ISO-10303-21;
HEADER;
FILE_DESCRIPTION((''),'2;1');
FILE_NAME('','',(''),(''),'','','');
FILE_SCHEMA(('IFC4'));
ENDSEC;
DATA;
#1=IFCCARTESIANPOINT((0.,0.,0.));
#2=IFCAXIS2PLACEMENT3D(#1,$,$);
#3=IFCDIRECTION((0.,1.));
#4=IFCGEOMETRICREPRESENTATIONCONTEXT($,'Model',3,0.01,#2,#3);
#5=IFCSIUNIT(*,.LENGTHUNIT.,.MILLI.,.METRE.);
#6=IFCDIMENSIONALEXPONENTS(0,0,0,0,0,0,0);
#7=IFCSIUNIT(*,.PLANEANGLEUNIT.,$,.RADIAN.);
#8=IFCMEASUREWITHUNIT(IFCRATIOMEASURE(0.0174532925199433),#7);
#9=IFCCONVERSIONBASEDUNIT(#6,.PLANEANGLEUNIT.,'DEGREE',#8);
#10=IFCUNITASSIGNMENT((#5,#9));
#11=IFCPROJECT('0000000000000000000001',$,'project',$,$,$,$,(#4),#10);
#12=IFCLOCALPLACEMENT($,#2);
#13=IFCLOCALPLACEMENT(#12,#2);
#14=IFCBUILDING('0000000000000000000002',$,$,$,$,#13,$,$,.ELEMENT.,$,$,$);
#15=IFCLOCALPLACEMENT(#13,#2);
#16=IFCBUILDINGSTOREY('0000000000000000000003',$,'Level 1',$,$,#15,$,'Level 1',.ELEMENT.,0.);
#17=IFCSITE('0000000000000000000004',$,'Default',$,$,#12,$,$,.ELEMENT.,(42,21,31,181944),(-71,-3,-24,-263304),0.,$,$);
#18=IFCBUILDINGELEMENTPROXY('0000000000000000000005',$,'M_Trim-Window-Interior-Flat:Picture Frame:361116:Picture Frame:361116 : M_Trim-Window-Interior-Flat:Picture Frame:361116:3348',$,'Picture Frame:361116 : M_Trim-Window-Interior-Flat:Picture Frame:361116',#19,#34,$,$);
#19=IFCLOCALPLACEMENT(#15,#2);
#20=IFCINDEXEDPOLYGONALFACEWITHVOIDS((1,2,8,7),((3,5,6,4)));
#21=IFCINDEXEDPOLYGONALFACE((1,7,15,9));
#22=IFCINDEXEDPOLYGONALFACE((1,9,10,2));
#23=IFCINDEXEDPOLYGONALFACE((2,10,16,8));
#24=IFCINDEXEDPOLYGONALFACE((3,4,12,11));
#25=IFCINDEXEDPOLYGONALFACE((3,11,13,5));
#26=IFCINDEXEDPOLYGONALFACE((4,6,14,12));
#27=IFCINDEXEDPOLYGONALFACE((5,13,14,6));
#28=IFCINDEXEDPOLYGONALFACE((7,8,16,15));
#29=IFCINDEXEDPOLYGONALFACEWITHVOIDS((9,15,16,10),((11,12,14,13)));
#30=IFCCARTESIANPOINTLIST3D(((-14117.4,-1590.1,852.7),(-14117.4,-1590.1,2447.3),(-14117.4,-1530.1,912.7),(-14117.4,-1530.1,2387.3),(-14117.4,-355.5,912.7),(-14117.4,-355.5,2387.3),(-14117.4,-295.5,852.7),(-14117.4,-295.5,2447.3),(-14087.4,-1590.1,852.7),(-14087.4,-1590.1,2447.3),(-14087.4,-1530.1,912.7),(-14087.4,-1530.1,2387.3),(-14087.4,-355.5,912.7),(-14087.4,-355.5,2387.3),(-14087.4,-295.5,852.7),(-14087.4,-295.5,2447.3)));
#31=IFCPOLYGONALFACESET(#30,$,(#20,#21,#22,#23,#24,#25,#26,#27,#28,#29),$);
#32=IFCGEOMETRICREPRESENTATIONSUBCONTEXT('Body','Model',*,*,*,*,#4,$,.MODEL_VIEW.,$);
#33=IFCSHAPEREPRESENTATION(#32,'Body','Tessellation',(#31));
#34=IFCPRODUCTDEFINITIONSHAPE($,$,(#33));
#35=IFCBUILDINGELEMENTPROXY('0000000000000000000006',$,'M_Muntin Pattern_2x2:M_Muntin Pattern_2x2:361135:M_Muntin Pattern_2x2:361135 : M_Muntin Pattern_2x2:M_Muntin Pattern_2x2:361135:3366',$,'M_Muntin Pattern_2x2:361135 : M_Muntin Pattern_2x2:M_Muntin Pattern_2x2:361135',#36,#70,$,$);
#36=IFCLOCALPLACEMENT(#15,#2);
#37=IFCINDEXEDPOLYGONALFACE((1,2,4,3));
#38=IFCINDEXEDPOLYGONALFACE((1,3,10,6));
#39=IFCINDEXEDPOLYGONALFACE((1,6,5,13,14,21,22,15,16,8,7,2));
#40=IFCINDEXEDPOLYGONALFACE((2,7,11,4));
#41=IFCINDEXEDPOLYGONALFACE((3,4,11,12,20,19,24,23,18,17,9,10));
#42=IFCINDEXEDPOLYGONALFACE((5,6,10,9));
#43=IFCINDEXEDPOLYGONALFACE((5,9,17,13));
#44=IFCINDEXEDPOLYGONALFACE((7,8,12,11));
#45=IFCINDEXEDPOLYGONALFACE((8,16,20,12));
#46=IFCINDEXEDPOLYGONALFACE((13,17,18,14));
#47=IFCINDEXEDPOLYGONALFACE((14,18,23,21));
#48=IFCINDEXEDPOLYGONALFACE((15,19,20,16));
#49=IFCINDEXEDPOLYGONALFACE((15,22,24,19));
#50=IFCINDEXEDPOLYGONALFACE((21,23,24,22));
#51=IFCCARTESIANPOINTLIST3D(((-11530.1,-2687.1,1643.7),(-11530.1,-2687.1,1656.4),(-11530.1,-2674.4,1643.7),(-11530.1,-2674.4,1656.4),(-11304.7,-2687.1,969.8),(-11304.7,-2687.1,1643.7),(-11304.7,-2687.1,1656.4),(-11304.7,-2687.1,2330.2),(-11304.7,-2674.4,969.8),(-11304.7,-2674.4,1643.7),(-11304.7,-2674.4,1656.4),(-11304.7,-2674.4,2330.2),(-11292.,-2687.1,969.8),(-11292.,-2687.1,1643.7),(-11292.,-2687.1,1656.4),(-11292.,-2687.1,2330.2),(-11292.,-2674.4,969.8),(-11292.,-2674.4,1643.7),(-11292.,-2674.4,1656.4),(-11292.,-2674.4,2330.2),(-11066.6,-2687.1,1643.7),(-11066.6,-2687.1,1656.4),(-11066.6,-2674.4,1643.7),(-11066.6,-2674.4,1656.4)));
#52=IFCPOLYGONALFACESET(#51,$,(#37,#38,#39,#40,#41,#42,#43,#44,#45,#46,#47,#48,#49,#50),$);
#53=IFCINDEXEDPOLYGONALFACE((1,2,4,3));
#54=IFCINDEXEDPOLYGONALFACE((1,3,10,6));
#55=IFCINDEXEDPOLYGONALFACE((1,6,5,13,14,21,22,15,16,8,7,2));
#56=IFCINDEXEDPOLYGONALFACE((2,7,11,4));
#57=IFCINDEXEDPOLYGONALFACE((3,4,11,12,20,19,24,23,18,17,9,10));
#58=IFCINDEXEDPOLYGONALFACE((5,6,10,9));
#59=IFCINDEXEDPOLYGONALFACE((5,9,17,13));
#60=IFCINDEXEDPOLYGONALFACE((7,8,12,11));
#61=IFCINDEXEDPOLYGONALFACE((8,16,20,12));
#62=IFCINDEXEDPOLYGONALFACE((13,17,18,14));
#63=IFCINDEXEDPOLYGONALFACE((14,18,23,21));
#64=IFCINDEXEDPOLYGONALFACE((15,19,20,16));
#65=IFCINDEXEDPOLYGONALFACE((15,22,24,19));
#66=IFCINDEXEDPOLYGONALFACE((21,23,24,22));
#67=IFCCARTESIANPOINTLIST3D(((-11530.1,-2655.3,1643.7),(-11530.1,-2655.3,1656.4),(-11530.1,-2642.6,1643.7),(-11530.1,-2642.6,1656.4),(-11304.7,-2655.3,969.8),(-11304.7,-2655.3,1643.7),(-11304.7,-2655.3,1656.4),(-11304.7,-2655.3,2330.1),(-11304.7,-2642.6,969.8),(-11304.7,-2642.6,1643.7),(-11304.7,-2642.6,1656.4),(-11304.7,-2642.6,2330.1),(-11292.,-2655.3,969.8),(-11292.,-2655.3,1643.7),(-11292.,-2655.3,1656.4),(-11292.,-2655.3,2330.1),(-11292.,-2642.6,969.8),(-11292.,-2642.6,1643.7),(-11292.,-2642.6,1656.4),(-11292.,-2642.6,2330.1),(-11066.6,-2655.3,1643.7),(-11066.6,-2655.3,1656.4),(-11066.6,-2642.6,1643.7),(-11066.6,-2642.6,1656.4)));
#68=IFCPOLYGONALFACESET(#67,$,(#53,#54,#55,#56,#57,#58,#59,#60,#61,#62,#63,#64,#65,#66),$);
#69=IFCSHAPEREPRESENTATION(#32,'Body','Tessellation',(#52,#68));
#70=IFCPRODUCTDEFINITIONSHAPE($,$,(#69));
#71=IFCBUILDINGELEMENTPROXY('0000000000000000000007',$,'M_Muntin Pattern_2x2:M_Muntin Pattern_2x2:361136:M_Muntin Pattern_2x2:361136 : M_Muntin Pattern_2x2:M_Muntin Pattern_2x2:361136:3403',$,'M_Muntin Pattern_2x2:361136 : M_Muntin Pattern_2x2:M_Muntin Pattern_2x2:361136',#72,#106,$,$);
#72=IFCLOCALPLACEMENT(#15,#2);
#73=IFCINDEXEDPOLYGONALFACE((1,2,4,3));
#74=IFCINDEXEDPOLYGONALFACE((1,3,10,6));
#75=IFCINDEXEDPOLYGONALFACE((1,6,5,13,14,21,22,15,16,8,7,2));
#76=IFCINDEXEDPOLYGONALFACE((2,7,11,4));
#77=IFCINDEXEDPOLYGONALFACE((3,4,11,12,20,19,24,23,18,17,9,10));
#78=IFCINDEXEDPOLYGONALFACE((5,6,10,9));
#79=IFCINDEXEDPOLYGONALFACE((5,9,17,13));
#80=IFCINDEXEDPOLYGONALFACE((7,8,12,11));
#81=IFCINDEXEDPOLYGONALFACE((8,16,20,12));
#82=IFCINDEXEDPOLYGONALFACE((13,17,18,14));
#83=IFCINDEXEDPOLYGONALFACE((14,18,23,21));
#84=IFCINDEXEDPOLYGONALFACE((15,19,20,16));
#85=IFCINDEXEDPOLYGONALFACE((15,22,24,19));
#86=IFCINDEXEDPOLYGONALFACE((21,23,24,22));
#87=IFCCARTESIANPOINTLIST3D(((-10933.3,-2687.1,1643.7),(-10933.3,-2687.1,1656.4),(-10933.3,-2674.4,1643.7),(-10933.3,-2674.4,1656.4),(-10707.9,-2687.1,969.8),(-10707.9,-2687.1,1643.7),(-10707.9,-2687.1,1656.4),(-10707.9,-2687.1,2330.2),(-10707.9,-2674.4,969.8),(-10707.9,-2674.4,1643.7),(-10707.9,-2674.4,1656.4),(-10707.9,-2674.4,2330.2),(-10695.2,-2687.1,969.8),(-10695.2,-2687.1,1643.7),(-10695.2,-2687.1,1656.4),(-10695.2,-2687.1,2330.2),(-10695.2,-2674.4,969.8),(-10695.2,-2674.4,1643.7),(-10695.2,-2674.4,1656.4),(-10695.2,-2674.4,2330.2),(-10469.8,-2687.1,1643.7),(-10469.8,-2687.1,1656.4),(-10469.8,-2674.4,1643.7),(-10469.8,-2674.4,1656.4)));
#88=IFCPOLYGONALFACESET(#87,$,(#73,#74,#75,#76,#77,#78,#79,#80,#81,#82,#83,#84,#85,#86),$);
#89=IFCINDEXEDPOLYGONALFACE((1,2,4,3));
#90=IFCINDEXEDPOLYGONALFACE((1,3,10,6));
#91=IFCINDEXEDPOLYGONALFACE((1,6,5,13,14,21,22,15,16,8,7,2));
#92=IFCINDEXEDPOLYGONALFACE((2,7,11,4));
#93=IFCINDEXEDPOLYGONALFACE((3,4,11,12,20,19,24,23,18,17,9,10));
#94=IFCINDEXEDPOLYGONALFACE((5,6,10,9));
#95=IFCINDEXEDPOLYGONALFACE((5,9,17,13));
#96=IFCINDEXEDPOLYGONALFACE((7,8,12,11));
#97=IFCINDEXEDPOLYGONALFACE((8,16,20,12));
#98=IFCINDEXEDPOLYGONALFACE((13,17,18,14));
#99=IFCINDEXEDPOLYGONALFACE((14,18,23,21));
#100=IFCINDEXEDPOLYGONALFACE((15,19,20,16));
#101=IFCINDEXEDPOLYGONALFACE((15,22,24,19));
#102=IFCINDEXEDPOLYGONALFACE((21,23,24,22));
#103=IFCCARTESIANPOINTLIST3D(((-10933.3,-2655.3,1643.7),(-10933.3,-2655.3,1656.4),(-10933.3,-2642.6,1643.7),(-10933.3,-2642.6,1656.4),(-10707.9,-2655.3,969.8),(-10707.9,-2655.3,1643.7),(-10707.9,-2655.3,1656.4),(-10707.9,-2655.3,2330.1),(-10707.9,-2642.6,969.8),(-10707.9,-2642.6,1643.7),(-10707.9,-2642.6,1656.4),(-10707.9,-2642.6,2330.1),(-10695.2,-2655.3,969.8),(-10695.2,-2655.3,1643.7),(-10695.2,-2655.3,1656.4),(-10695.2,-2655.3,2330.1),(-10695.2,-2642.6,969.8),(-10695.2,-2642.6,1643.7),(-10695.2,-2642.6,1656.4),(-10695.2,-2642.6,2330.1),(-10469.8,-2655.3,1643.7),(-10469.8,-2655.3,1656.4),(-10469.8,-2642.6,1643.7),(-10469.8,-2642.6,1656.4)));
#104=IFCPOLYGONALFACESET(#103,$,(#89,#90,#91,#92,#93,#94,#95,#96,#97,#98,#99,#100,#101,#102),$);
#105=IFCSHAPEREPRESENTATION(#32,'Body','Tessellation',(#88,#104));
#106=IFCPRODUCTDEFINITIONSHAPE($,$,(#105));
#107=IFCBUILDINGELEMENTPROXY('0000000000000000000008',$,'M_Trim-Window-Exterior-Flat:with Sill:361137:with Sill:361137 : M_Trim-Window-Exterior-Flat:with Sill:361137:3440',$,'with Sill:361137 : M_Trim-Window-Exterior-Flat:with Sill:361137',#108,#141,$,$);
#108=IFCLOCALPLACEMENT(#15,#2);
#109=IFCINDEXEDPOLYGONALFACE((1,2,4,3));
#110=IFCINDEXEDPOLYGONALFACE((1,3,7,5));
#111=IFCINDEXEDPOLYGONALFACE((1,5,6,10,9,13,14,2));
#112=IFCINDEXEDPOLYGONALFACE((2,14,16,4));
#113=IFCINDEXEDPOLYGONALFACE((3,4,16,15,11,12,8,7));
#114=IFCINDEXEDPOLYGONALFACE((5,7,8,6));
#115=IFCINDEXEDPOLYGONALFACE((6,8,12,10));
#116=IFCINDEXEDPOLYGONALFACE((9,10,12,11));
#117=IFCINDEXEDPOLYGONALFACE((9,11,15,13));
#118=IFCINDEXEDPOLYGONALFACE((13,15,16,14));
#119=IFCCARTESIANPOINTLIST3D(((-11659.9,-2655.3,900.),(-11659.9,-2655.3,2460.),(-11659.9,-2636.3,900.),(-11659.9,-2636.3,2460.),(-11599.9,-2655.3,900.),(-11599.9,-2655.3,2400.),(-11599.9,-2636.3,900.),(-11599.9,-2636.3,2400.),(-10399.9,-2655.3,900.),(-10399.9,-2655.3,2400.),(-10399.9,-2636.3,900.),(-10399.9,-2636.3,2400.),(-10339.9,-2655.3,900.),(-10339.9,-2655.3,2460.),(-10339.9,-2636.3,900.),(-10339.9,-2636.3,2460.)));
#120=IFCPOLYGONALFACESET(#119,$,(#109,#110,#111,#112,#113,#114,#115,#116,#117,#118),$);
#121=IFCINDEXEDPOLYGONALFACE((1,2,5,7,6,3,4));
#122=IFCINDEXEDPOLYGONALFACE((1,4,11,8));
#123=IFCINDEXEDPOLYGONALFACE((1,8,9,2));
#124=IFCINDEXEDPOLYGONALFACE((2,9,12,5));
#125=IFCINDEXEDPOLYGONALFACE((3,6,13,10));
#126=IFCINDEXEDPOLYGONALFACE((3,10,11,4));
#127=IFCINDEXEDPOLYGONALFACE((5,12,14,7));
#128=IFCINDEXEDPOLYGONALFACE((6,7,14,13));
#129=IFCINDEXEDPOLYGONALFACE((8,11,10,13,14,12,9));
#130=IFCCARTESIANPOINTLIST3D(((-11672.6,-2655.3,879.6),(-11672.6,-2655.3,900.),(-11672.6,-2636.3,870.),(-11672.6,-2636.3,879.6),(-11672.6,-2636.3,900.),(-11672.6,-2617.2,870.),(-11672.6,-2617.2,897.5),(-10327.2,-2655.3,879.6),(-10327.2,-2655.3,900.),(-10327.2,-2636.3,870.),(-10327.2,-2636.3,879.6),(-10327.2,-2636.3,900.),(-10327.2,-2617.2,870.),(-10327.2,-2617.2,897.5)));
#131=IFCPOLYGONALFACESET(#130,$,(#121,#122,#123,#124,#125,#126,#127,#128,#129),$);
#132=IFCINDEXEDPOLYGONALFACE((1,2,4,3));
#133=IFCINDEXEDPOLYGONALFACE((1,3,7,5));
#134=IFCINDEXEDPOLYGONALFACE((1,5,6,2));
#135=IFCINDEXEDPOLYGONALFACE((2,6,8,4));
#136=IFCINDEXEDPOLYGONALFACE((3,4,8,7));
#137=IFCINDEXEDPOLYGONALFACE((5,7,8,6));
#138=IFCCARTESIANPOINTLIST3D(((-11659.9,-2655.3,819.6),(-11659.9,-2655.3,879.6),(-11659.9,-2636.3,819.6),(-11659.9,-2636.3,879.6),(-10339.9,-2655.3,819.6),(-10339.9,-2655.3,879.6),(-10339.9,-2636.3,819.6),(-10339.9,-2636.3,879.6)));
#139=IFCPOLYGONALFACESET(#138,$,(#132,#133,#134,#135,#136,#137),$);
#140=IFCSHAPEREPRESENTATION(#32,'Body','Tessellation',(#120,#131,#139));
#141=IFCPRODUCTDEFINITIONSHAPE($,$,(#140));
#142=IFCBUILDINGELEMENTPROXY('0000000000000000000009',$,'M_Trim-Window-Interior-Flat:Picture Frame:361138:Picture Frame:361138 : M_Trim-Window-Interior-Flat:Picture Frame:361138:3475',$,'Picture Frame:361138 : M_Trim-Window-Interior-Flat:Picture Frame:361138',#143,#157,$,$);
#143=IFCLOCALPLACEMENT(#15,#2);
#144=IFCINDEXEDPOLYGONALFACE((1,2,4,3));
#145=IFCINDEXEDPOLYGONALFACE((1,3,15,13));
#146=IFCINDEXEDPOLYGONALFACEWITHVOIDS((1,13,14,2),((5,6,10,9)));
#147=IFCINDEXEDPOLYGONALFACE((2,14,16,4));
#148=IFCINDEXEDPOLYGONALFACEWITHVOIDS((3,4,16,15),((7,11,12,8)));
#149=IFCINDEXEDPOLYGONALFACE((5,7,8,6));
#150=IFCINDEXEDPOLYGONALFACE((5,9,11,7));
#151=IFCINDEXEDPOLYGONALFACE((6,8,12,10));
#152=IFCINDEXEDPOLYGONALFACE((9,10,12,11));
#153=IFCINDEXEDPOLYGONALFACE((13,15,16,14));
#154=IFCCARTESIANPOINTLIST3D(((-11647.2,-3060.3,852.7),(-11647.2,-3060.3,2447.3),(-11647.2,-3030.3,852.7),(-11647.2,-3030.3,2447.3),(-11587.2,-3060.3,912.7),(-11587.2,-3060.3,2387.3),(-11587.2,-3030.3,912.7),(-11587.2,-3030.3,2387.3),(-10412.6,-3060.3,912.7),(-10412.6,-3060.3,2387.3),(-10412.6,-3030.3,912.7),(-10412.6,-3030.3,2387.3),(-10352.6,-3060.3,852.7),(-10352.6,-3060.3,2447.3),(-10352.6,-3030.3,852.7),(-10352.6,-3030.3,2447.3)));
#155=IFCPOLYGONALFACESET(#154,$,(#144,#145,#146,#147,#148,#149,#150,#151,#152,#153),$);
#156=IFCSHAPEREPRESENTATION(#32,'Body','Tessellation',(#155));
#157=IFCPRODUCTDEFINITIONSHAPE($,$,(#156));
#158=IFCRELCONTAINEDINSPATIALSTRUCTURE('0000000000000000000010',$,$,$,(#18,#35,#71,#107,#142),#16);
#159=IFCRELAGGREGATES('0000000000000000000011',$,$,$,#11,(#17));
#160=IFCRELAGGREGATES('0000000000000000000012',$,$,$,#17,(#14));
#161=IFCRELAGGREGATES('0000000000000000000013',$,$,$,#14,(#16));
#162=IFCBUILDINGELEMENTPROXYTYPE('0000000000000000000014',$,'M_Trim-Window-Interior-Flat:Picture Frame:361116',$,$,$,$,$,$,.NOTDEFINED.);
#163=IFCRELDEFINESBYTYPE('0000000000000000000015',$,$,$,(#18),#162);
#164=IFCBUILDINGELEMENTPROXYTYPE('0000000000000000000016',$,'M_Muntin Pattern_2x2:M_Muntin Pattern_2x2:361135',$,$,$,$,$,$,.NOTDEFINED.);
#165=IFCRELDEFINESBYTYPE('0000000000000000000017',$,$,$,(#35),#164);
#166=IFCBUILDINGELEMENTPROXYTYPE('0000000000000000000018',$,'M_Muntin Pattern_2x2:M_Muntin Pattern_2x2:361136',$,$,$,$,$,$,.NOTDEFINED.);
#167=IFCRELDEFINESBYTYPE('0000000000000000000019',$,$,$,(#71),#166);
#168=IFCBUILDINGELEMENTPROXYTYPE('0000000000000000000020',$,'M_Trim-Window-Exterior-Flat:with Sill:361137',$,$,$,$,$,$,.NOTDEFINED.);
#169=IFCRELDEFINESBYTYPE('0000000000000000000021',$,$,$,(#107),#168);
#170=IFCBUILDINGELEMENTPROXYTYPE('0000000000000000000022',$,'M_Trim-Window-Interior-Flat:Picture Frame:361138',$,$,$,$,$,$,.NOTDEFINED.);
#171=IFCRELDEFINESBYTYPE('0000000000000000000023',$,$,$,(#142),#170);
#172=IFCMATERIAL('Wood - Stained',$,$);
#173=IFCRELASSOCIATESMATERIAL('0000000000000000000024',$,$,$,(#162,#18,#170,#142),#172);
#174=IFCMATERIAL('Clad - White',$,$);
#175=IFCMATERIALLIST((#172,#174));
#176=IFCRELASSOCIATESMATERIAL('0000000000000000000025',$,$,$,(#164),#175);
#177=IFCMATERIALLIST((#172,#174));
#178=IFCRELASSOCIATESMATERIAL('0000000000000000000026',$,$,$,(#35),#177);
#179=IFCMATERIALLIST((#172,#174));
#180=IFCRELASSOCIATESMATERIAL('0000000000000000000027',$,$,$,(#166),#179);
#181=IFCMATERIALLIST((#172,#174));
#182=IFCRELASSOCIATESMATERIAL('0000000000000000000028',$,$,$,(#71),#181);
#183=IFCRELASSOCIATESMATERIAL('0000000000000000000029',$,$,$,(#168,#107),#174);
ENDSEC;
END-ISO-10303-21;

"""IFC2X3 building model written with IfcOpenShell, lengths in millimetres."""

from ifc_helpers import new_model, entity, si_unit, converted_unit, direction, frame, origin, origin_2d_with_axis, place, context, subcontext, project, spatial, polyline, rectangle, outline, extrude, source, transform, mapped, material, material_list, type_object, type_shapes, element, save


model = new_model("IFC2X3")

# Units and contexts
model_context = context("Model", 3, precision=0.01, world=origin(), true_north=direction((0.0, 1.0)))
body_context = subcontext(model_context, "Body", "Model", "MODEL_VIEW")
ifc_project = project(units=[si_unit("LENGTHUNIT", "METRE", prefix="MILLI"), converted_unit("PLANEANGLEUNIT", "DEGREE", entity("IfcRatioMeasure", 0.0174532925199433), si_unit("PLANEANGLEUNIT", "RADIAN"), dimensions=[0, 0, 0, 0, 0, 0, 0])], contexts=[model_context])

# Site, building, storey
site_placement = place(None, origin())
site = spatial("IfcSite", under=ifc_project, at=site_placement, Name="Default", CompositionType="ELEMENT", RefLatitude=(42, 21, 31, 181944), RefLongitude=(-71, -3, -24, -263304), RefElevation=0.0)
building_placement = place(site_placement, origin())
building = spatial("IfcBuilding", under=site, at=building_placement, CompositionType="ELEMENT")
storey_placement = place(building_placement, origin())
storey = spatial("IfcBuildingStorey", under=building, at=storey_placement, Name="Level 1", LongName="Level 1", CompositionType="ELEMENT", Elevation=0.0)

# Building element proxies
ifc_material_1 = material(Name="Wood - Stained")
ifc_material_2 = material(Name="Clad - White")
building_element_proxy_type_1 = type_object("IfcBuildingElementProxyType", Name="M_Trim-Window-Interior-Flat:Picture Frame:361116", PredefinedType="NOTDEFINED", material=ifc_material_1)
shared_shape_1 = source(origin(), body_context, "Body", "SweptSolid", [
    extrude(outline(polyline([(-647.3, -797.3), (647.3, -797.3), (647.3, 797.3), (-647.3, 797.3), (-647.3, -797.3)]), holes=[polyline([(587.3, 737.3), (587.3, -737.3), (-587.3, -737.3), (-587.3, 737.3), (587.3, 737.3)])]), frame((-14117.4, -942.8, 1650.0), z_axis=(1.0, 0.0, 0.0), x_axis=(0.0, -1.0, 0.0)), (0.0, 0.0, 1.0), 30.0),
])
type_shapes(building_element_proxy_type_1, [shared_shape_1])
proxy_1_placement = place(storey_placement, origin())
element("IfcBuildingElementProxy", 1, at=proxy_1_placement, inside=storey, type_object=building_element_proxy_type_1, material=ifc_material_1, Name="M_Trim-Window-Interior-Flat:Picture Frame:361116:Picture Frame:361116 : M_Trim-Window-Interior-Flat:Picture Frame:361116:3348", ObjectType="Picture Frame:361116 : M_Trim-Window-Interior-Flat:Picture Frame:361116", context=body_context, shape_type="MappedRepresentation", body=[
    mapped(shared_shape_1, transform((0.0, 0.0, 0.0), scale=1.0)),
])
ifc_material_list_1 = material_list([ifc_material_1, ifc_material_2])
ifc_material_list_2 = material_list([ifc_material_1, ifc_material_2])
building_element_proxy_type_2 = type_object("IfcBuildingElementProxyType", Name="M_Muntin Pattern_2x2:M_Muntin Pattern_2x2:361135", PredefinedType="NOTDEFINED", material=ifc_material_list_2)
shared_shape_2 = source(origin(), body_context, "Body", "SweptSolid", [
    extrude(outline(polyline([(-6.4, -680.2), (6.3, -680.2), (6.3, -6.4), (231.7, -6.4), (231.7, 6.3), (6.3, 6.3), (6.3, 680.2), (-6.4, 680.2), (-6.4, 6.3), (-231.7, 6.3), (-231.7, -6.4), (-6.4, -6.4), (-6.4, -680.2)])), frame((-11298.4, -2687.1, 1650.0), z_axis=(0.0, 1.0, 0.0), x_axis=(1.0, 0.0, 0.0)), (0.0, 0.0, 1.0), 12.7),
    extrude(outline(polyline([(-6.4, -680.1), (6.3, -680.1), (6.3, -6.4), (231.7, -6.4), (231.7, 6.3), (6.3, 6.3), (6.3, 680.2), (-6.4, 680.2), (-6.4, 6.3), (-231.7, 6.3), (-231.7, -6.4), (-6.4, -6.4), (-6.4, -680.1)])), frame((-11298.4, -2655.3, 1650.0), z_axis=(0.0, 1.0, 0.0), x_axis=(1.0, 0.0, 0.0)), (0.0, 0.0, 1.0), 12.7),
])
type_shapes(building_element_proxy_type_2, [shared_shape_2])
proxy_2_placement = place(storey_placement, origin())
element("IfcBuildingElementProxy", 2, at=proxy_2_placement, inside=storey, type_object=building_element_proxy_type_2, material=ifc_material_list_1, Name="M_Muntin Pattern_2x2:M_Muntin Pattern_2x2:361135:M_Muntin Pattern_2x2:361135 : M_Muntin Pattern_2x2:M_Muntin Pattern_2x2:361135:3366", ObjectType="M_Muntin Pattern_2x2:361135 : M_Muntin Pattern_2x2:M_Muntin Pattern_2x2:361135", context=body_context, shape_type="MappedRepresentation", body=[
    mapped(shared_shape_2, transform((0.0, 0.0, 0.0), scale=1.0)),
])
ifc_material_list_3 = material_list([ifc_material_1, ifc_material_2])
ifc_material_list_4 = material_list([ifc_material_1, ifc_material_2])
building_element_proxy_type_3 = type_object("IfcBuildingElementProxyType", Name="M_Muntin Pattern_2x2:M_Muntin Pattern_2x2:361136", PredefinedType="NOTDEFINED", material=ifc_material_list_4)
shared_shape_3 = source(origin(), body_context, "Body", "SweptSolid", [
    extrude(outline(polyline([(-680.1, 6.4), (-680.1, -6.3), (-6.4, -6.3), (-6.4, -231.7), (6.3, -231.7), (6.3, -6.3), (680.2, -6.3), (680.2, 6.4), (6.3, 6.4), (6.3, 231.7), (-6.4, 231.7), (-6.4, 6.4), (-680.1, 6.4)])), frame((-10701.5, -2687.1, 1650.0), z_axis=(0.0, -1.0, 0.0), x_axis=(0.0, 0.0, -1.0)), (0.0, 0.0, -1.0), 12.7),
    extrude(outline(polyline([(-680.1, 6.4), (-680.1, -6.3), (-6.4, -6.3), (-6.4, -231.7), (6.3, -231.7), (6.3, -6.3), (680.2, -6.3), (680.2, 6.4), (6.3, 6.4), (6.3, 231.7), (-6.4, 231.7), (-6.4, 6.4), (-680.1, 6.4)])), frame((-10701.5, -2655.3, 1650.0), z_axis=(0.0, -1.0, 0.0), x_axis=(0.0, 0.0, -1.0)), (0.0, 0.0, -1.0), 12.7),
])
type_shapes(building_element_proxy_type_3, [shared_shape_3])
proxy_3_placement = place(storey_placement, origin())
element("IfcBuildingElementProxy", 3, at=proxy_3_placement, inside=storey, type_object=building_element_proxy_type_3, material=ifc_material_list_3, Name="M_Muntin Pattern_2x2:M_Muntin Pattern_2x2:361136:M_Muntin Pattern_2x2:361136 : M_Muntin Pattern_2x2:M_Muntin Pattern_2x2:361136:3403", ObjectType="M_Muntin Pattern_2x2:361136 : M_Muntin Pattern_2x2:M_Muntin Pattern_2x2:361136", context=body_context, shape_type="MappedRepresentation", body=[
    mapped(shared_shape_3, transform((0.0, 0.0, 0.0), scale=1.0)),
])
building_element_proxy_type_4 = type_object("IfcBuildingElementProxyType", Name="M_Trim-Window-Exterior-Flat:with Sill:361137", PredefinedType="NOTDEFINED", material=ifc_material_2)
shared_shape_4 = source(origin(), body_context, "Body", "SweptSolid", [
    extrude(outline(polyline([(-660.0, -765.0), (-600.0, -765.0), (-600.0, 735.0), (600.0, 735.0), (600.0, -765.0), (660.0, -765.0), (660.0, 795.0), (-660.0, 795.0), (-660.0, -765.0)])), frame((-10999.9, -2655.3, 1665.0), z_axis=(0.0, 1.0, 0.0), x_axis=(-1.0, 0.0, 0.0)), (0.0, 0.0, 1.0), 19.1),
    extrude(outline(polyline([(0.0, -15.2), (19.0, -15.2), (19.0, 12.3), (0.0, 14.8), (-19.0, 14.8), (-19.0, -5.7), (0.0, -5.7), (0.0, -15.2)])), frame((-11672.6, -2636.3, 885.2), z_axis=(1.0, 0.0, 0.0), x_axis=(0.0, 1.0, 0.0)), (0.0, 0.0, 1.0), 1345.4),
    extrude(rectangle(XDim=19.1, YDim=1320.0, at=origin_2d_with_axis()), frame((-10999.9, -2645.8, 819.6), z_axis=(0.0, 0.0, 1.0), x_axis=(0.0, -1.0, 0.0)), (0.0, 0.0, 1.0), 60.0),
])
type_shapes(building_element_proxy_type_4, [shared_shape_4])
proxy_4_placement = place(storey_placement, origin())
element("IfcBuildingElementProxy", 4, at=proxy_4_placement, inside=storey, type_object=building_element_proxy_type_4, material=ifc_material_2, Name="M_Trim-Window-Exterior-Flat:with Sill:361137:with Sill:361137 : M_Trim-Window-Exterior-Flat:with Sill:361137:3440", ObjectType="with Sill:361137 : M_Trim-Window-Exterior-Flat:with Sill:361137", context=body_context, shape_type="MappedRepresentation", body=[
    mapped(shared_shape_4, transform((0.0, 0.0, 0.0), scale=1.0)),
])
building_element_proxy_type_5 = type_object("IfcBuildingElementProxyType", Name="M_Trim-Window-Interior-Flat:Picture Frame:361138", PredefinedType="NOTDEFINED", material=ifc_material_1)
shared_shape_5 = source(origin(), body_context, "Body", "SweptSolid", [
    extrude(outline(polyline([(-647.3, -797.3), (647.3, -797.3), (647.3, 797.3), (-647.3, 797.3), (-647.3, -797.3)]), holes=[polyline([(587.3, 737.3), (587.3, -737.3), (-587.3, -737.3), (-587.3, 737.3), (587.3, 737.3)])]), frame((-10999.9, -3060.3, 1650.0), z_axis=(0.0, 1.0, 0.0), x_axis=(1.0, 0.0, 0.0)), (0.0, 0.0, 1.0), 30.0),
])
type_shapes(building_element_proxy_type_5, [shared_shape_5])
proxy_5_placement = place(storey_placement, origin())
element("IfcBuildingElementProxy", 5, at=proxy_5_placement, inside=storey, type_object=building_element_proxy_type_5, material=ifc_material_1, Name="M_Trim-Window-Interior-Flat:Picture Frame:361138:Picture Frame:361138 : M_Trim-Window-Interior-Flat:Picture Frame:361138:3475", ObjectType="Picture Frame:361138 : M_Trim-Window-Interior-Flat:Picture Frame:361138", context=body_context, shape_type="MappedRepresentation", body=[
    mapped(shared_shape_5, transform((0.0, 0.0, 0.0), scale=1.0)),
])

save(model, "model.ifc")
